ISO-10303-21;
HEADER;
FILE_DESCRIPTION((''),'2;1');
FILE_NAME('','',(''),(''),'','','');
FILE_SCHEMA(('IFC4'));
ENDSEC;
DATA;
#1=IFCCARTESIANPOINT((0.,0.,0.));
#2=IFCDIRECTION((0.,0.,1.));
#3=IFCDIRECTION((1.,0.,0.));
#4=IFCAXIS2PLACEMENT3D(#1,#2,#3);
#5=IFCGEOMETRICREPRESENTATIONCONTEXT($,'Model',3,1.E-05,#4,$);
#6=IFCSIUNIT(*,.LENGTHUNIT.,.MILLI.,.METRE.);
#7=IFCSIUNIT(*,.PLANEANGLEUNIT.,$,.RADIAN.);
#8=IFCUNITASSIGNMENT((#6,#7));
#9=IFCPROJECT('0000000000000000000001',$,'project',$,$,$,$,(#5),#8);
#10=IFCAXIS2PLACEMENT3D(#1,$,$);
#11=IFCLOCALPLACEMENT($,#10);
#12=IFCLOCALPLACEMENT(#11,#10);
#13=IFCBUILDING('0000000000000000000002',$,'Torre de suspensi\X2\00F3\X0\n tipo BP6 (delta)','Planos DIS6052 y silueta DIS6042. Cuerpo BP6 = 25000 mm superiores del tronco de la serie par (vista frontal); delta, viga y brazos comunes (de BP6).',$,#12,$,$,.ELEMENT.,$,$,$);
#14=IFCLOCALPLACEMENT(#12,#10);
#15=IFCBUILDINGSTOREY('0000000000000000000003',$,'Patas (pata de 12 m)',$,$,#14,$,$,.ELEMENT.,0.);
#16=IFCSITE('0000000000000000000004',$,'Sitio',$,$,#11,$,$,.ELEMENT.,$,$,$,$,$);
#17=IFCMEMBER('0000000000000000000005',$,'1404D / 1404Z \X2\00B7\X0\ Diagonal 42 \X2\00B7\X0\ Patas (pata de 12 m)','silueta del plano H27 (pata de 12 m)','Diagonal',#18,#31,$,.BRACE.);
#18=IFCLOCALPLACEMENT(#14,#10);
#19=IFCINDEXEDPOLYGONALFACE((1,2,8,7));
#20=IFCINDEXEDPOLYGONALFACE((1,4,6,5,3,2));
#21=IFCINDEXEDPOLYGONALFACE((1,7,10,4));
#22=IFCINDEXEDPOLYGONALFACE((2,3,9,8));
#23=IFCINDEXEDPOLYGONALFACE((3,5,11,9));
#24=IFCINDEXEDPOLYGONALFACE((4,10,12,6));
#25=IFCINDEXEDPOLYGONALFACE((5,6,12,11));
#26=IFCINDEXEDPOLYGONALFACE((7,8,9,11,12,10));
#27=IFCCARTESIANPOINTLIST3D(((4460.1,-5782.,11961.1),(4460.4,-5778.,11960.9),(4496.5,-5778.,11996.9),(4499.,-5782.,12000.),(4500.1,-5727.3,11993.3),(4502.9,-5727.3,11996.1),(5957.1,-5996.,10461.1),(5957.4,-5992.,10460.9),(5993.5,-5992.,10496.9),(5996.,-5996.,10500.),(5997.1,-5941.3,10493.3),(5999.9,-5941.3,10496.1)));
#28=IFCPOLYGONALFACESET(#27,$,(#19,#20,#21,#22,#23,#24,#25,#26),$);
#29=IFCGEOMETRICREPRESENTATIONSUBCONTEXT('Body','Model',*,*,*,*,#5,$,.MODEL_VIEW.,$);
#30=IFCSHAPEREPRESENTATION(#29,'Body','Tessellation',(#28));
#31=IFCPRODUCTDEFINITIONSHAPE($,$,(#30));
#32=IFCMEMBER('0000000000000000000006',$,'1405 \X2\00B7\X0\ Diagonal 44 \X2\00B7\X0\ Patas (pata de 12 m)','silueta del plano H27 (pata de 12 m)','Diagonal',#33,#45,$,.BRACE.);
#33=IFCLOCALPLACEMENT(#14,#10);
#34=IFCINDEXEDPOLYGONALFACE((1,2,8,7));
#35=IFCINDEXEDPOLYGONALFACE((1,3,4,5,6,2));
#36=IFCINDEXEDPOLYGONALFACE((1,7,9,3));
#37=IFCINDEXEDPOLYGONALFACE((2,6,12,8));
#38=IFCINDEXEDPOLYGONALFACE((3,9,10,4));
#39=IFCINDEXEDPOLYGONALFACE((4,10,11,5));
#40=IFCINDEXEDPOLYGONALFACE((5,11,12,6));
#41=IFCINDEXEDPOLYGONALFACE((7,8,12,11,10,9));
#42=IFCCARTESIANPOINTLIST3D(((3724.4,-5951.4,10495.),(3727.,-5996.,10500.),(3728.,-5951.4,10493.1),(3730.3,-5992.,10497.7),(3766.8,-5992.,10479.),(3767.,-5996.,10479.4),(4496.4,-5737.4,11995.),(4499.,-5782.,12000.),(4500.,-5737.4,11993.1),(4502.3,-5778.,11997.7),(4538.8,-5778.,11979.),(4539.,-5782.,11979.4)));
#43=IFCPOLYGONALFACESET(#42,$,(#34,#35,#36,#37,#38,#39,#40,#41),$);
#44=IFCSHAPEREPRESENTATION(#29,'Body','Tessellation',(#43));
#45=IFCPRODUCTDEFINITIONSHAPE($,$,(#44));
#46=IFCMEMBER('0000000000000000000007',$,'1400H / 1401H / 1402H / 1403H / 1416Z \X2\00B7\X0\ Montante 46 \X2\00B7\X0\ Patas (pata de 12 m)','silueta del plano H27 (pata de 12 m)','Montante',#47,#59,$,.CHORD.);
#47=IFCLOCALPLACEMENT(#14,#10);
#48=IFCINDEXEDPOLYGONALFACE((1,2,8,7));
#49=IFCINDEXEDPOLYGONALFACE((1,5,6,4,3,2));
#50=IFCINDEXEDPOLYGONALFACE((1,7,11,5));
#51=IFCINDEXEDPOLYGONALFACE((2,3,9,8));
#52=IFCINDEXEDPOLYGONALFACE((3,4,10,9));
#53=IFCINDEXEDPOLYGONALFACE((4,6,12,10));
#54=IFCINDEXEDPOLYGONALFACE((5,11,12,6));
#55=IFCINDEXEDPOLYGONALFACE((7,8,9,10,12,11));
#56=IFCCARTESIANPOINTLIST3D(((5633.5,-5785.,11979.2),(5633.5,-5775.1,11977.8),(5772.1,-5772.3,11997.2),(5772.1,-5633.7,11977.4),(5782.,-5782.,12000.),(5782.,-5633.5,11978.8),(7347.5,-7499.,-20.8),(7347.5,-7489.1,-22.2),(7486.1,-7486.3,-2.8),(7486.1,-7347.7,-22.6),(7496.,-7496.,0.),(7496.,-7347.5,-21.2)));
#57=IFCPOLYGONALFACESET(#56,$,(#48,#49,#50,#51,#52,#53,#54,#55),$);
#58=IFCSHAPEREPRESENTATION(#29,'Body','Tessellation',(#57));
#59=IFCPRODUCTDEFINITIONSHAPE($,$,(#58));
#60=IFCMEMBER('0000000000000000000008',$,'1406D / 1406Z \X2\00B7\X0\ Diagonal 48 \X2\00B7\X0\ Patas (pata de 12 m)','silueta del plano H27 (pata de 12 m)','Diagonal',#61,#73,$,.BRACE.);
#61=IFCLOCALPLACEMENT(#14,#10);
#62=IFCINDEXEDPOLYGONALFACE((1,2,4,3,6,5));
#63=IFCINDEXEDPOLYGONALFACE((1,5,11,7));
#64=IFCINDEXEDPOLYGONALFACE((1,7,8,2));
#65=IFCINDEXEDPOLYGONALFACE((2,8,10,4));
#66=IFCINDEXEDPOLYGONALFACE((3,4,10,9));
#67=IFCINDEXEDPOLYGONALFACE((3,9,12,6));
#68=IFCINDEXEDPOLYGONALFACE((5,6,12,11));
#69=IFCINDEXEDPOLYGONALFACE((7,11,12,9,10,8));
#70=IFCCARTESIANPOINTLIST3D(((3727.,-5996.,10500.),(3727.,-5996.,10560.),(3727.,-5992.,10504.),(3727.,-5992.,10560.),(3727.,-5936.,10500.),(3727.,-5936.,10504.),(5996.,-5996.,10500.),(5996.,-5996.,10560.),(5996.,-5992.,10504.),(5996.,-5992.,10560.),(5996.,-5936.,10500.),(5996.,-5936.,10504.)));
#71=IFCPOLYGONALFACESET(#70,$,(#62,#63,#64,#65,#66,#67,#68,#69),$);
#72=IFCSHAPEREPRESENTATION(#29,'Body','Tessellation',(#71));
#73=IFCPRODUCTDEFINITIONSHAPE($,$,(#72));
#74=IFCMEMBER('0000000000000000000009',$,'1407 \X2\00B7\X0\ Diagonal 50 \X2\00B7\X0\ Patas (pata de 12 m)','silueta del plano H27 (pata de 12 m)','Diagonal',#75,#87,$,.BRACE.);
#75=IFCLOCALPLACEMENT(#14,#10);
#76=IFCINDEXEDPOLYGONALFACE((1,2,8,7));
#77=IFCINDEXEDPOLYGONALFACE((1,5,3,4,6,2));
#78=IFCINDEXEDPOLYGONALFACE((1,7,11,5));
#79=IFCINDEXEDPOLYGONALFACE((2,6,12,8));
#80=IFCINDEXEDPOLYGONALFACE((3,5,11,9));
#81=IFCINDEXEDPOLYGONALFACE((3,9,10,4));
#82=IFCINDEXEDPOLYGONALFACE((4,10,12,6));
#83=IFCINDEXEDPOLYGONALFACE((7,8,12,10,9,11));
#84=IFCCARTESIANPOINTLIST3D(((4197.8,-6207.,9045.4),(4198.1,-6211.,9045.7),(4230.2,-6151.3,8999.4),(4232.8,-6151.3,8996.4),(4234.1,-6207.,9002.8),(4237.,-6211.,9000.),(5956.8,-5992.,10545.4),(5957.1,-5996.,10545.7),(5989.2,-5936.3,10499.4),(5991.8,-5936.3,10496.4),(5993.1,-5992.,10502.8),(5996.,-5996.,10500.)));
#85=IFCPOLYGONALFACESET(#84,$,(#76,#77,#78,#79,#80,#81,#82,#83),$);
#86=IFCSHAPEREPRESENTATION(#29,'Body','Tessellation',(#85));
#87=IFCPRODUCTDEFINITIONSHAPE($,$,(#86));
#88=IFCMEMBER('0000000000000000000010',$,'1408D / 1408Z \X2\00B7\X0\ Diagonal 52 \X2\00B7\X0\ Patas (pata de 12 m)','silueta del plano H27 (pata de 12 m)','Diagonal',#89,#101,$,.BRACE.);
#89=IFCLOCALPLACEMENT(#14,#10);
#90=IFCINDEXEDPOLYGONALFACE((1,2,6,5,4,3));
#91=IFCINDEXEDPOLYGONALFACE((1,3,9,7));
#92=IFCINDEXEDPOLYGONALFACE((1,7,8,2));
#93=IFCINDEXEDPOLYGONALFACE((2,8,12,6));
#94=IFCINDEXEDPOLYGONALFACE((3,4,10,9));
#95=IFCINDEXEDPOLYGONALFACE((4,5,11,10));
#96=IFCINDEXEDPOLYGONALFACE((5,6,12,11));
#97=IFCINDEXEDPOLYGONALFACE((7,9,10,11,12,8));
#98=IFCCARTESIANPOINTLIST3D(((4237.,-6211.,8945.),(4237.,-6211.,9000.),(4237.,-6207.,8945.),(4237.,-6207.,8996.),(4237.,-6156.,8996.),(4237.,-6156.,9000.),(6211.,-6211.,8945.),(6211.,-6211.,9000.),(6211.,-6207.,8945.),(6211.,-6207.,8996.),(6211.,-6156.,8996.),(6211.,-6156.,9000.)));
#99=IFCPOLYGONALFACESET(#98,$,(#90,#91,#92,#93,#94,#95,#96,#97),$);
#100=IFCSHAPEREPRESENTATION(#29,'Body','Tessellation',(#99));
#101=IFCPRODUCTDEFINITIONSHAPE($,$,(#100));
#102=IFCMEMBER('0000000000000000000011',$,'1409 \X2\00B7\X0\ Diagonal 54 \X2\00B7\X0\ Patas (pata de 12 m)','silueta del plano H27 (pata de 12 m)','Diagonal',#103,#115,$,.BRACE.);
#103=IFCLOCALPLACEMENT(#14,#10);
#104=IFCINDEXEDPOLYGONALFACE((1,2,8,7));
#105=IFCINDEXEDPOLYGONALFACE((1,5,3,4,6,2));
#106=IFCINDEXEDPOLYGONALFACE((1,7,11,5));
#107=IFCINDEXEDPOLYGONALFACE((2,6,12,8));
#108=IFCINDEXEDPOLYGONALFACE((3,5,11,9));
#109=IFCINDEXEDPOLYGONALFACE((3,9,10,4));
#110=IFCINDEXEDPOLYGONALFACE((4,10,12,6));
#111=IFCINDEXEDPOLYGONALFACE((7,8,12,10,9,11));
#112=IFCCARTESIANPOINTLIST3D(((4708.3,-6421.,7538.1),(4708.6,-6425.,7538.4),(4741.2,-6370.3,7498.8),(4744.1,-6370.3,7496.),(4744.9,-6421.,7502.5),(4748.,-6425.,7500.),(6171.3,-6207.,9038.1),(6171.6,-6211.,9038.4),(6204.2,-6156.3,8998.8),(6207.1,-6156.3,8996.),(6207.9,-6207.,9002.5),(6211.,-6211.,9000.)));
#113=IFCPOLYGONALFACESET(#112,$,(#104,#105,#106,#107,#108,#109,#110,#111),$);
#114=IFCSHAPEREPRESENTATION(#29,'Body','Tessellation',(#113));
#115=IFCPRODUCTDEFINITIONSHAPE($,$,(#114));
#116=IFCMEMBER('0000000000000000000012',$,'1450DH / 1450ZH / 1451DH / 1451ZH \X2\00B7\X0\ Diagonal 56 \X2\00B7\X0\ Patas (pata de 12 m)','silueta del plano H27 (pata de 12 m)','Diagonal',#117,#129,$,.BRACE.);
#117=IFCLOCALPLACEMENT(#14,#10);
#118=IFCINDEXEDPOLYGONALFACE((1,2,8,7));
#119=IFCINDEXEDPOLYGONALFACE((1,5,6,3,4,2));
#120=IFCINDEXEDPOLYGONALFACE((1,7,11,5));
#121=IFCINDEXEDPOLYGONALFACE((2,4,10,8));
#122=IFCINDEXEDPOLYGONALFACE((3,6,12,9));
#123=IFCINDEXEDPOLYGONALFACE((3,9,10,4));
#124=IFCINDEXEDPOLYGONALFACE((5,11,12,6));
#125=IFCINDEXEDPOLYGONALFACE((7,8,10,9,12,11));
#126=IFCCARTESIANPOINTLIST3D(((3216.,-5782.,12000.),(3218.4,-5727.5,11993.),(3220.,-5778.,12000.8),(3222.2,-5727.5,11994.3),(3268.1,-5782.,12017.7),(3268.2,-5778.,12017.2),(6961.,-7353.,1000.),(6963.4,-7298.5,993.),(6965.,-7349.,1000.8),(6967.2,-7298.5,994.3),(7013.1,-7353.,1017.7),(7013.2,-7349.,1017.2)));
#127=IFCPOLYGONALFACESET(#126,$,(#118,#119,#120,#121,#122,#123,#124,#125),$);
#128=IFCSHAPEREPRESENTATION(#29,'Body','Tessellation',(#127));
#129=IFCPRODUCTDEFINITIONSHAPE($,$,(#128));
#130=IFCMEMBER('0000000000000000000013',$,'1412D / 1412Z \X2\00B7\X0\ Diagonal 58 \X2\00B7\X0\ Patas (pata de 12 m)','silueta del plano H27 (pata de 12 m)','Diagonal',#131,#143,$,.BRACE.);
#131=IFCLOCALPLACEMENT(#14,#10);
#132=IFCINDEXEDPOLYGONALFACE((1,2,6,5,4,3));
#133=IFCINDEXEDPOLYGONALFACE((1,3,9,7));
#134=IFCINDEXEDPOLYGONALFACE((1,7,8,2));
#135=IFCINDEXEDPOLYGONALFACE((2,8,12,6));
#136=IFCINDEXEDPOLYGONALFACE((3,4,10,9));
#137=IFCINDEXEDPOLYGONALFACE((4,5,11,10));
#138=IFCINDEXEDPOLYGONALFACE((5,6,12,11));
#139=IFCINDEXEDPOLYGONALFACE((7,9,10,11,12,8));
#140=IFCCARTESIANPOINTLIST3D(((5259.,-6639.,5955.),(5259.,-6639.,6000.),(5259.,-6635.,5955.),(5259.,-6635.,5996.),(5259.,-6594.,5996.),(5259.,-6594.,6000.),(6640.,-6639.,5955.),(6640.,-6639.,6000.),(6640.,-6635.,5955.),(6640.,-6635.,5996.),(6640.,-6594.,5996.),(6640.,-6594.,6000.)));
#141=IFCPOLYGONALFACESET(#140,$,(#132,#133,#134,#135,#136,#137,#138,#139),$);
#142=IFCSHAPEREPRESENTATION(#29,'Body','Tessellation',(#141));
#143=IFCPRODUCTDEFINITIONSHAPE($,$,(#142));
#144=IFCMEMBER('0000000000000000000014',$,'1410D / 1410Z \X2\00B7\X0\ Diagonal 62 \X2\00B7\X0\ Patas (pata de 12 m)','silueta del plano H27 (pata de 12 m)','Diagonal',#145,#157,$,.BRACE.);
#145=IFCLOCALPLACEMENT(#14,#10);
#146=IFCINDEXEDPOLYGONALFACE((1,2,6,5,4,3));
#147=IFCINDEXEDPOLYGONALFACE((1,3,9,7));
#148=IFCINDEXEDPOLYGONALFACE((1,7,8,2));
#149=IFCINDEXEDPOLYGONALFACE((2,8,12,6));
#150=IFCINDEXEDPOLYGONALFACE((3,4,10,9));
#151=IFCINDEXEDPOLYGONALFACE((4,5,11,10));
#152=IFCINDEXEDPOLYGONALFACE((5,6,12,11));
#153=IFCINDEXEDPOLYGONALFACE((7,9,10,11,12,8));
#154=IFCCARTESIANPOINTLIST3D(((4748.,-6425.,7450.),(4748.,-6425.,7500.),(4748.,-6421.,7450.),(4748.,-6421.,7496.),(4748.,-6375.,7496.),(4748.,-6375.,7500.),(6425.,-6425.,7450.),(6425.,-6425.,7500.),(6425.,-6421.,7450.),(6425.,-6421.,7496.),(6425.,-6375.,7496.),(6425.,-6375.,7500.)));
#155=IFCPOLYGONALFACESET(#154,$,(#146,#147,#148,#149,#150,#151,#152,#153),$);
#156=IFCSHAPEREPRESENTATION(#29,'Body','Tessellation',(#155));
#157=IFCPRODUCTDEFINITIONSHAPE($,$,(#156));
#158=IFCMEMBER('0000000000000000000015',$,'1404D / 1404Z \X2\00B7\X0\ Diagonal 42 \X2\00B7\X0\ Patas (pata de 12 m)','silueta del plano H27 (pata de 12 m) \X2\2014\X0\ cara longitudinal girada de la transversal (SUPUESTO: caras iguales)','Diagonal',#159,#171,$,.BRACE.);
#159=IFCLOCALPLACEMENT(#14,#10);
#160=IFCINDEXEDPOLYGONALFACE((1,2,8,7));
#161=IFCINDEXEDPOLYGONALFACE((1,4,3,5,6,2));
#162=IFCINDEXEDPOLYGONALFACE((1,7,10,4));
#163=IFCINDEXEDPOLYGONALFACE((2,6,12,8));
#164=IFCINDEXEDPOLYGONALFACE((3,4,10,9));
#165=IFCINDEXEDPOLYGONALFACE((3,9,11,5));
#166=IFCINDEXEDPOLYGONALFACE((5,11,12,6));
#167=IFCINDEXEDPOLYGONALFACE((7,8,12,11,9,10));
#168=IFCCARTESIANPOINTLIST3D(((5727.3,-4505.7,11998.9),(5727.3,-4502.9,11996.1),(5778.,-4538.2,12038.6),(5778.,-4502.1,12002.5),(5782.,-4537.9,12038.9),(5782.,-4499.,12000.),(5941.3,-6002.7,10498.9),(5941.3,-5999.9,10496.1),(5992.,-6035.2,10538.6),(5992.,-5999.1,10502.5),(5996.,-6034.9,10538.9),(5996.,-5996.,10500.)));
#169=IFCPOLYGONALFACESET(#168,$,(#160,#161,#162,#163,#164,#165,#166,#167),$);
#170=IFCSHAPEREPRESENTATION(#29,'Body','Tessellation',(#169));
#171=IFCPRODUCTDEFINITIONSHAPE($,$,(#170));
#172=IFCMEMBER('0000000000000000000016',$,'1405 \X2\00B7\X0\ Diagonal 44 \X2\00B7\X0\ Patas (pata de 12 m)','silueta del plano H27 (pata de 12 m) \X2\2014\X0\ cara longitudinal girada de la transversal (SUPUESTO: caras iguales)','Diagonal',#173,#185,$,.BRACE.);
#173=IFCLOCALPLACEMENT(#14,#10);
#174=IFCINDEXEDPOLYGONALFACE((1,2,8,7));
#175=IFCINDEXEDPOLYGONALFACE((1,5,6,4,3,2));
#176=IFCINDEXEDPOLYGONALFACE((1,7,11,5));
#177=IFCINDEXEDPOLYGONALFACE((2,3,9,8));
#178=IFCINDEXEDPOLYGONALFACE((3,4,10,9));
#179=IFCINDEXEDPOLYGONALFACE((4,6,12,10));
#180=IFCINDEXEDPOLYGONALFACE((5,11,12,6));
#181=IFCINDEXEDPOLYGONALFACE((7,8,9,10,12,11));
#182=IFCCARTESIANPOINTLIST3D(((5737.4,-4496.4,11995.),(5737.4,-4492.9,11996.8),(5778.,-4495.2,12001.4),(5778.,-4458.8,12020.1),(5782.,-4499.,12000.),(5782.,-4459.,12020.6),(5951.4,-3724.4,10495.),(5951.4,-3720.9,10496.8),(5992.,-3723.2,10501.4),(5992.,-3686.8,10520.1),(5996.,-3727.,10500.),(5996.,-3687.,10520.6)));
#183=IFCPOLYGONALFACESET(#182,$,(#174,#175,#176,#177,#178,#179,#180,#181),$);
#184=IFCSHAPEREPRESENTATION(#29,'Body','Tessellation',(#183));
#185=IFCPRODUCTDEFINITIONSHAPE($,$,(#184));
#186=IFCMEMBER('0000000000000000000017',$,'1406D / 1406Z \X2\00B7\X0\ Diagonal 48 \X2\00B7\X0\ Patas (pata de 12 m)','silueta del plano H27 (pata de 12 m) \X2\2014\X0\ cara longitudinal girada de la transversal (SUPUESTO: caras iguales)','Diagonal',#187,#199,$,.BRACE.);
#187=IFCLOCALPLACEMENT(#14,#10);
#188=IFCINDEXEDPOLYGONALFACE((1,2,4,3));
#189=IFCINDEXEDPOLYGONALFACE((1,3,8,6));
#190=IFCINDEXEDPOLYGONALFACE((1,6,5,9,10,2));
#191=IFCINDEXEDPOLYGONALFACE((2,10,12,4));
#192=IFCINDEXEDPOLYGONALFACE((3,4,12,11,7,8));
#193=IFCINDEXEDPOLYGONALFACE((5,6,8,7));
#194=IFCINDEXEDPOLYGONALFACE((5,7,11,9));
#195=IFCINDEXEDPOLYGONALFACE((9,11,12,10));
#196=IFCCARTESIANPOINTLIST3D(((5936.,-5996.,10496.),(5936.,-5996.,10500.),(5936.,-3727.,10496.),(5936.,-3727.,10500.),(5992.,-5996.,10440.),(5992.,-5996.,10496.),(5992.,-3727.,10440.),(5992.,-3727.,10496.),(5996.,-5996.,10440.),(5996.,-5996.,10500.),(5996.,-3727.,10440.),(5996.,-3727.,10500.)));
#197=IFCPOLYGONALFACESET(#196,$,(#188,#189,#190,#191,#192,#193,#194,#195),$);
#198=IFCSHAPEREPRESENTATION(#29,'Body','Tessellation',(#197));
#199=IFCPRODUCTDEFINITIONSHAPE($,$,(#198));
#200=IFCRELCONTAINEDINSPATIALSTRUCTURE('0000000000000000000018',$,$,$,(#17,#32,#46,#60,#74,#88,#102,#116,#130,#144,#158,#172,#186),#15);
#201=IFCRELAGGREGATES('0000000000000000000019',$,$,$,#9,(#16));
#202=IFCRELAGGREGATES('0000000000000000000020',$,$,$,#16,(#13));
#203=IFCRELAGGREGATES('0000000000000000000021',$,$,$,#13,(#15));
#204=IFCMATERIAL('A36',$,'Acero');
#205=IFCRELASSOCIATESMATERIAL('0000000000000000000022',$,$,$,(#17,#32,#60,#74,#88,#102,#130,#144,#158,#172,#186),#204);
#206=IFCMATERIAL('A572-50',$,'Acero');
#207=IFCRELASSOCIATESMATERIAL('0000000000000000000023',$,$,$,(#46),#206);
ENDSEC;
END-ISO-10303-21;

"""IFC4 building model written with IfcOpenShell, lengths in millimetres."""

from ifc_helpers import new_model, si_unit, frame, frame_2d, origin, origin_with_axes, place, context, subcontext, project, spatial, l_section, extrude, material, element, save


model = new_model("IFC4")

# Units and contexts
model_context = context("Model", 3, precision=1e-05, world=origin_with_axes())
body_context = subcontext(model_context, "Body", "Model", "MODEL_VIEW")
ifc_project = project(units=[si_unit("LENGTHUNIT", "METRE", prefix="MILLI"), si_unit("PLANEANGLEUNIT", "RADIAN")], contexts=[model_context])

# Site, building, storey
site_placement = place(None, origin())
site = spatial("IfcSite", under=ifc_project, at=site_placement, Name="Sitio", CompositionType="ELEMENT")
building_placement = place(site_placement, origin())
building = spatial("IfcBuilding", under=site, at=building_placement, Name="Torre de suspensión tipo BP6 (delta)", Description="Planos DIS6052 y silueta DIS6042. Cuerpo BP6 = 25000 mm superiores del tronco de la serie par (vista frontal); delta, viga y brazos comunes (de BP6).", CompositionType="ELEMENT")
storey_placement = place(building_placement, origin())
storey = spatial("IfcBuildingStorey", under=building, at=storey_placement, Name="Patas (pata de 12 m)", CompositionType="ELEMENT", Elevation=0.0)

# Members
ifc_material_1 = material(Name="A36", Category="Acero")
member_1_placement = place(storey_placement, frame((5996.0, -5996.0, 10500.0), z_axis=(-0.702824, 0.100471, 0.704233), x_axis=(0.070972, 0.99494, -0.071114)))
element("IfcMember", 1, at=member_1_placement, inside=storey, material=ifc_material_1, Name="1404D / 1404Z · Diagonal 42 · Patas (pata de 12 m)", Description="silueta del plano H27 (pata de 12 m)", ObjectType="Diagonal", PredefinedType="BRACE", context=body_context, shape_type="SweptSolid", body=[
    extrude(l_section(Depth=55.0, Width=55.0, Thickness=4.0, at=frame_2d((27.5, 27.5))), None, (0.0, 0.0, 1.0), 2130.0),
])
member_2_placement = place(storey_placement, frame((4499.0, -5782.0, 12000.0), z_axis=(-0.453978, -0.125844, -0.882081), x_axis=(-0.057588, 0.99205, -0.111894)))
element("IfcMember", 2, at=member_2_placement, inside=storey, material=ifc_material_1, Name="1405 · Diagonal 44 · Patas (pata de 12 m)", Description="silueta del plano H27 (pata de 12 m)", ObjectType="Diagonal", PredefinedType="BRACE", context=body_context, shape_type="SweptSolid", body=[
    extrude(l_section(Depth=45.0, Width=45.0, Thickness=4.0, at=frame_2d((22.5, 22.5))), None, (0.0, 0.0, 1.0), 1700.5),
])
ifc_material_2 = material(Name="A572-50", Category="Acero")
member_3_placement = place(storey_placement, frame((5782.0, -5782.0, 12000.0), z_axis=(0.140006, -0.140006, -0.980202), x_axis=(-0.990151, -0.019797, -0.138599)))
element("IfcMember", 3, at=member_3_placement, inside=storey, material=ifc_material_2, Name="1400H / 1401H / 1402H / 1403H / 1416Z · Montante 46 · Patas (pata de 12 m)", Description="silueta del plano H27 (pata de 12 m)", ObjectType="Montante", PredefinedType="CHORD", context=body_context, shape_type="SweptSolid", body=[
    extrude(l_section(Depth=150.0, Width=150.0, Thickness=10.0, at=frame_2d((75.0, 75.0))), None, (0.0, 0.0, 1.0), 12242.4),
])
member_4_placement = place(storey_placement, frame((3727.0, -5996.0, 10500.0), z_axis=(1.0, 0.0, 0.0), x_axis=(0.0, 1.0, 0.0)))
element("IfcMember", 4, at=member_4_placement, inside=storey, material=ifc_material_1, Name="1406D / 1406Z · Diagonal 48 · Patas (pata de 12 m)", Description="silueta del plano H27 (pata de 12 m)", ObjectType="Diagonal", PredefinedType="BRACE", context=body_context, shape_type="SweptSolid", body=[
    extrude(l_section(Depth=60.0, Width=60.0, Thickness=4.0, at=frame_2d((30.0, 30.0))), None, (0.0, 0.0, 1.0), 2269.0),
])
member_5_placement = place(storey_placement, frame((4237.0, -6211.0, 9000.0), z_axis=(0.757633, 0.092604, 0.646077), x_axis=(-0.070463, 0.995703, -0.060088)))
element("IfcMember", 5, at=member_5_placement, inside=storey, material=ifc_material_1, Name="1407 · Diagonal 50 · Patas (pata de 12 m)", Description="silueta del plano H27 (pata de 12 m)", ObjectType="Diagonal", PredefinedType="BRACE", context=body_context, shape_type="SweptSolid", body=[
    extrude(l_section(Depth=60.0, Width=60.0, Thickness=4.0, at=frame_2d((30.0, 30.0))), None, (0.0, 0.0, 1.0), 2321.7),
])
member_6_placement = place(storey_placement, frame((6211.0, -6211.0, 9000.0), z_axis=(-1.0, 0.0, 0.0), x_axis=(0.0, 1.0, 0.0)))
element("IfcMember", 6, at=member_6_placement, inside=storey, material=ifc_material_1, Name="1408D / 1408Z · Diagonal 52 · Patas (pata de 12 m)", Description="silueta del plano H27 (pata de 12 m)", ObjectType="Diagonal", PredefinedType="BRACE", context=body_context, shape_type="SweptSolid", body=[
    extrude(l_section(Depth=55.0, Width=55.0, Thickness=4.0, at=frame_2d((27.5, 27.5))), None, (0.0, 0.0, 1.0), 1974.0),
])
member_7_placement = place(storey_placement, frame((4748.0, -6425.0, 7500.0), z_axis=(0.694609, 0.101604, 0.712176), x_axis=(-0.070942, 0.994825, -0.072736)))
element("IfcMember", 7, at=member_7_placement, inside=storey, material=ifc_material_1, Name="1409 · Diagonal 54 · Patas (pata de 12 m)", Description="silueta del plano H27 (pata de 12 m)", ObjectType="Diagonal", PredefinedType="BRACE", context=body_context, shape_type="SweptSolid", body=[
    extrude(l_section(Depth=55.0, Width=55.0, Thickness=4.0, at=frame_2d((27.5, 27.5))), None, (0.0, 0.0, 1.0), 2106.2),
])
member_8_placement = place(storey_placement, frame((3216.0, -5782.0, 12000.0), z_axis=(0.319383, -0.133979, -0.938107), x_axis=(0.04318, 0.990984, -0.12683)))
element("IfcMember", 8, at=member_8_placement, inside=storey, Name="1450DH / 1450ZH / 1451DH / 1451ZH · Diagonal 56 · Patas (pata de 12 m)", Description="silueta del plano H27 (pata de 12 m)", ObjectType="Diagonal", PredefinedType="BRACE", context=body_context, shape_type="SweptSolid", body=[
    extrude(l_section(Depth=55.0, Width=55.0, Thickness=4.0, at=frame_2d((27.5, 27.5))), None, (0.0, 0.0, 1.0), 11725.7),
])
member_9_placement = place(storey_placement, frame((6640.0, -6639.0, 6000.0), z_axis=(-1.0, 0.0, 0.0), x_axis=(0.0, 1.0, 0.0)))
element("IfcMember", 9, at=member_9_placement, inside=storey, material=ifc_material_1, Name="1412D / 1412Z · Diagonal 58 · Patas (pata de 12 m)", Description="silueta del plano H27 (pata de 12 m)", ObjectType="Diagonal", PredefinedType="BRACE", context=body_context, shape_type="SweptSolid", body=[
    extrude(l_section(Depth=45.0, Width=45.0, Thickness=4.0, at=frame_2d((22.5, 22.5))), None, (0.0, 0.0, 1.0), 1381.0),
])
member_10_placement = place(storey_placement, frame((6425.0, -6425.0, 7500.0), z_axis=(-1.0, 0.0, 0.0), x_axis=(0.0, 1.0, 0.0)))
element("IfcMember", 10, at=member_10_placement, inside=storey, material=ifc_material_1, Name="1410D / 1410Z · Diagonal 62 · Patas (pata de 12 m)", Description="silueta del plano H27 (pata de 12 m)", ObjectType="Diagonal", PredefinedType="BRACE", context=body_context, shape_type="SweptSolid", body=[
    extrude(l_section(Depth=50.0, Width=50.0, Thickness=4.0, at=frame_2d((25.0, 25.0))), None, (0.0, 0.0, 1.0), 1677.0),
])
member_11_placement = place(storey_placement, frame((5996.0, -5996.0, 10500.0), z_axis=(-0.100471, 0.702824, 0.704233), x_axis=(-0.99494, -0.070972, -0.071114)))
element("IfcMember", 11, at=member_11_placement, inside=storey, material=ifc_material_1, Name="1404D / 1404Z · Diagonal 42 · Patas (pata de 12 m)", Description="silueta del plano H27 (pata de 12 m) — cara longitudinal girada de la transversal (SUPUESTO: caras iguales)", ObjectType="Diagonal", PredefinedType="BRACE", context=body_context, shape_type="SweptSolid", body=[
    extrude(l_section(Depth=55.0, Width=55.0, Thickness=4.0, at=frame_2d((27.5, 27.5))), None, (0.0, 0.0, 1.0), 2130.0),
])
member_12_placement = place(storey_placement, frame((5782.0, -4499.0, 12000.0), z_axis=(0.125844, 0.453978, -0.882081), x_axis=(-0.99205, 0.057588, -0.111894)))
element("IfcMember", 12, at=member_12_placement, inside=storey, material=ifc_material_1, Name="1405 · Diagonal 44 · Patas (pata de 12 m)", Description="silueta del plano H27 (pata de 12 m) — cara longitudinal girada de la transversal (SUPUESTO: caras iguales)", ObjectType="Diagonal", PredefinedType="BRACE", context=body_context, shape_type="SweptSolid", body=[
    extrude(l_section(Depth=45.0, Width=45.0, Thickness=4.0, at=frame_2d((22.5, 22.5))), None, (0.0, 0.0, 1.0), 1700.5),
])
member_13_placement = place(storey_placement, frame((5996.0, -3727.0, 10500.0), z_axis=(0.0, -1.0, 0.0), x_axis=(-1.0, 0.0, 0.0)))
element("IfcMember", 13, at=member_13_placement, inside=storey, material=ifc_material_1, Name="1406D / 1406Z · Diagonal 48 · Patas (pata de 12 m)", Description="silueta del plano H27 (pata de 12 m) — cara longitudinal girada de la transversal (SUPUESTO: caras iguales)", ObjectType="Diagonal", PredefinedType="BRACE", context=body_context, shape_type="SweptSolid", body=[
    extrude(l_section(Depth=60.0, Width=60.0, Thickness=4.0, at=frame_2d((30.0, 30.0))), None, (0.0, 0.0, 1.0), 2269.0),
])

save(model, "model.ifc")
